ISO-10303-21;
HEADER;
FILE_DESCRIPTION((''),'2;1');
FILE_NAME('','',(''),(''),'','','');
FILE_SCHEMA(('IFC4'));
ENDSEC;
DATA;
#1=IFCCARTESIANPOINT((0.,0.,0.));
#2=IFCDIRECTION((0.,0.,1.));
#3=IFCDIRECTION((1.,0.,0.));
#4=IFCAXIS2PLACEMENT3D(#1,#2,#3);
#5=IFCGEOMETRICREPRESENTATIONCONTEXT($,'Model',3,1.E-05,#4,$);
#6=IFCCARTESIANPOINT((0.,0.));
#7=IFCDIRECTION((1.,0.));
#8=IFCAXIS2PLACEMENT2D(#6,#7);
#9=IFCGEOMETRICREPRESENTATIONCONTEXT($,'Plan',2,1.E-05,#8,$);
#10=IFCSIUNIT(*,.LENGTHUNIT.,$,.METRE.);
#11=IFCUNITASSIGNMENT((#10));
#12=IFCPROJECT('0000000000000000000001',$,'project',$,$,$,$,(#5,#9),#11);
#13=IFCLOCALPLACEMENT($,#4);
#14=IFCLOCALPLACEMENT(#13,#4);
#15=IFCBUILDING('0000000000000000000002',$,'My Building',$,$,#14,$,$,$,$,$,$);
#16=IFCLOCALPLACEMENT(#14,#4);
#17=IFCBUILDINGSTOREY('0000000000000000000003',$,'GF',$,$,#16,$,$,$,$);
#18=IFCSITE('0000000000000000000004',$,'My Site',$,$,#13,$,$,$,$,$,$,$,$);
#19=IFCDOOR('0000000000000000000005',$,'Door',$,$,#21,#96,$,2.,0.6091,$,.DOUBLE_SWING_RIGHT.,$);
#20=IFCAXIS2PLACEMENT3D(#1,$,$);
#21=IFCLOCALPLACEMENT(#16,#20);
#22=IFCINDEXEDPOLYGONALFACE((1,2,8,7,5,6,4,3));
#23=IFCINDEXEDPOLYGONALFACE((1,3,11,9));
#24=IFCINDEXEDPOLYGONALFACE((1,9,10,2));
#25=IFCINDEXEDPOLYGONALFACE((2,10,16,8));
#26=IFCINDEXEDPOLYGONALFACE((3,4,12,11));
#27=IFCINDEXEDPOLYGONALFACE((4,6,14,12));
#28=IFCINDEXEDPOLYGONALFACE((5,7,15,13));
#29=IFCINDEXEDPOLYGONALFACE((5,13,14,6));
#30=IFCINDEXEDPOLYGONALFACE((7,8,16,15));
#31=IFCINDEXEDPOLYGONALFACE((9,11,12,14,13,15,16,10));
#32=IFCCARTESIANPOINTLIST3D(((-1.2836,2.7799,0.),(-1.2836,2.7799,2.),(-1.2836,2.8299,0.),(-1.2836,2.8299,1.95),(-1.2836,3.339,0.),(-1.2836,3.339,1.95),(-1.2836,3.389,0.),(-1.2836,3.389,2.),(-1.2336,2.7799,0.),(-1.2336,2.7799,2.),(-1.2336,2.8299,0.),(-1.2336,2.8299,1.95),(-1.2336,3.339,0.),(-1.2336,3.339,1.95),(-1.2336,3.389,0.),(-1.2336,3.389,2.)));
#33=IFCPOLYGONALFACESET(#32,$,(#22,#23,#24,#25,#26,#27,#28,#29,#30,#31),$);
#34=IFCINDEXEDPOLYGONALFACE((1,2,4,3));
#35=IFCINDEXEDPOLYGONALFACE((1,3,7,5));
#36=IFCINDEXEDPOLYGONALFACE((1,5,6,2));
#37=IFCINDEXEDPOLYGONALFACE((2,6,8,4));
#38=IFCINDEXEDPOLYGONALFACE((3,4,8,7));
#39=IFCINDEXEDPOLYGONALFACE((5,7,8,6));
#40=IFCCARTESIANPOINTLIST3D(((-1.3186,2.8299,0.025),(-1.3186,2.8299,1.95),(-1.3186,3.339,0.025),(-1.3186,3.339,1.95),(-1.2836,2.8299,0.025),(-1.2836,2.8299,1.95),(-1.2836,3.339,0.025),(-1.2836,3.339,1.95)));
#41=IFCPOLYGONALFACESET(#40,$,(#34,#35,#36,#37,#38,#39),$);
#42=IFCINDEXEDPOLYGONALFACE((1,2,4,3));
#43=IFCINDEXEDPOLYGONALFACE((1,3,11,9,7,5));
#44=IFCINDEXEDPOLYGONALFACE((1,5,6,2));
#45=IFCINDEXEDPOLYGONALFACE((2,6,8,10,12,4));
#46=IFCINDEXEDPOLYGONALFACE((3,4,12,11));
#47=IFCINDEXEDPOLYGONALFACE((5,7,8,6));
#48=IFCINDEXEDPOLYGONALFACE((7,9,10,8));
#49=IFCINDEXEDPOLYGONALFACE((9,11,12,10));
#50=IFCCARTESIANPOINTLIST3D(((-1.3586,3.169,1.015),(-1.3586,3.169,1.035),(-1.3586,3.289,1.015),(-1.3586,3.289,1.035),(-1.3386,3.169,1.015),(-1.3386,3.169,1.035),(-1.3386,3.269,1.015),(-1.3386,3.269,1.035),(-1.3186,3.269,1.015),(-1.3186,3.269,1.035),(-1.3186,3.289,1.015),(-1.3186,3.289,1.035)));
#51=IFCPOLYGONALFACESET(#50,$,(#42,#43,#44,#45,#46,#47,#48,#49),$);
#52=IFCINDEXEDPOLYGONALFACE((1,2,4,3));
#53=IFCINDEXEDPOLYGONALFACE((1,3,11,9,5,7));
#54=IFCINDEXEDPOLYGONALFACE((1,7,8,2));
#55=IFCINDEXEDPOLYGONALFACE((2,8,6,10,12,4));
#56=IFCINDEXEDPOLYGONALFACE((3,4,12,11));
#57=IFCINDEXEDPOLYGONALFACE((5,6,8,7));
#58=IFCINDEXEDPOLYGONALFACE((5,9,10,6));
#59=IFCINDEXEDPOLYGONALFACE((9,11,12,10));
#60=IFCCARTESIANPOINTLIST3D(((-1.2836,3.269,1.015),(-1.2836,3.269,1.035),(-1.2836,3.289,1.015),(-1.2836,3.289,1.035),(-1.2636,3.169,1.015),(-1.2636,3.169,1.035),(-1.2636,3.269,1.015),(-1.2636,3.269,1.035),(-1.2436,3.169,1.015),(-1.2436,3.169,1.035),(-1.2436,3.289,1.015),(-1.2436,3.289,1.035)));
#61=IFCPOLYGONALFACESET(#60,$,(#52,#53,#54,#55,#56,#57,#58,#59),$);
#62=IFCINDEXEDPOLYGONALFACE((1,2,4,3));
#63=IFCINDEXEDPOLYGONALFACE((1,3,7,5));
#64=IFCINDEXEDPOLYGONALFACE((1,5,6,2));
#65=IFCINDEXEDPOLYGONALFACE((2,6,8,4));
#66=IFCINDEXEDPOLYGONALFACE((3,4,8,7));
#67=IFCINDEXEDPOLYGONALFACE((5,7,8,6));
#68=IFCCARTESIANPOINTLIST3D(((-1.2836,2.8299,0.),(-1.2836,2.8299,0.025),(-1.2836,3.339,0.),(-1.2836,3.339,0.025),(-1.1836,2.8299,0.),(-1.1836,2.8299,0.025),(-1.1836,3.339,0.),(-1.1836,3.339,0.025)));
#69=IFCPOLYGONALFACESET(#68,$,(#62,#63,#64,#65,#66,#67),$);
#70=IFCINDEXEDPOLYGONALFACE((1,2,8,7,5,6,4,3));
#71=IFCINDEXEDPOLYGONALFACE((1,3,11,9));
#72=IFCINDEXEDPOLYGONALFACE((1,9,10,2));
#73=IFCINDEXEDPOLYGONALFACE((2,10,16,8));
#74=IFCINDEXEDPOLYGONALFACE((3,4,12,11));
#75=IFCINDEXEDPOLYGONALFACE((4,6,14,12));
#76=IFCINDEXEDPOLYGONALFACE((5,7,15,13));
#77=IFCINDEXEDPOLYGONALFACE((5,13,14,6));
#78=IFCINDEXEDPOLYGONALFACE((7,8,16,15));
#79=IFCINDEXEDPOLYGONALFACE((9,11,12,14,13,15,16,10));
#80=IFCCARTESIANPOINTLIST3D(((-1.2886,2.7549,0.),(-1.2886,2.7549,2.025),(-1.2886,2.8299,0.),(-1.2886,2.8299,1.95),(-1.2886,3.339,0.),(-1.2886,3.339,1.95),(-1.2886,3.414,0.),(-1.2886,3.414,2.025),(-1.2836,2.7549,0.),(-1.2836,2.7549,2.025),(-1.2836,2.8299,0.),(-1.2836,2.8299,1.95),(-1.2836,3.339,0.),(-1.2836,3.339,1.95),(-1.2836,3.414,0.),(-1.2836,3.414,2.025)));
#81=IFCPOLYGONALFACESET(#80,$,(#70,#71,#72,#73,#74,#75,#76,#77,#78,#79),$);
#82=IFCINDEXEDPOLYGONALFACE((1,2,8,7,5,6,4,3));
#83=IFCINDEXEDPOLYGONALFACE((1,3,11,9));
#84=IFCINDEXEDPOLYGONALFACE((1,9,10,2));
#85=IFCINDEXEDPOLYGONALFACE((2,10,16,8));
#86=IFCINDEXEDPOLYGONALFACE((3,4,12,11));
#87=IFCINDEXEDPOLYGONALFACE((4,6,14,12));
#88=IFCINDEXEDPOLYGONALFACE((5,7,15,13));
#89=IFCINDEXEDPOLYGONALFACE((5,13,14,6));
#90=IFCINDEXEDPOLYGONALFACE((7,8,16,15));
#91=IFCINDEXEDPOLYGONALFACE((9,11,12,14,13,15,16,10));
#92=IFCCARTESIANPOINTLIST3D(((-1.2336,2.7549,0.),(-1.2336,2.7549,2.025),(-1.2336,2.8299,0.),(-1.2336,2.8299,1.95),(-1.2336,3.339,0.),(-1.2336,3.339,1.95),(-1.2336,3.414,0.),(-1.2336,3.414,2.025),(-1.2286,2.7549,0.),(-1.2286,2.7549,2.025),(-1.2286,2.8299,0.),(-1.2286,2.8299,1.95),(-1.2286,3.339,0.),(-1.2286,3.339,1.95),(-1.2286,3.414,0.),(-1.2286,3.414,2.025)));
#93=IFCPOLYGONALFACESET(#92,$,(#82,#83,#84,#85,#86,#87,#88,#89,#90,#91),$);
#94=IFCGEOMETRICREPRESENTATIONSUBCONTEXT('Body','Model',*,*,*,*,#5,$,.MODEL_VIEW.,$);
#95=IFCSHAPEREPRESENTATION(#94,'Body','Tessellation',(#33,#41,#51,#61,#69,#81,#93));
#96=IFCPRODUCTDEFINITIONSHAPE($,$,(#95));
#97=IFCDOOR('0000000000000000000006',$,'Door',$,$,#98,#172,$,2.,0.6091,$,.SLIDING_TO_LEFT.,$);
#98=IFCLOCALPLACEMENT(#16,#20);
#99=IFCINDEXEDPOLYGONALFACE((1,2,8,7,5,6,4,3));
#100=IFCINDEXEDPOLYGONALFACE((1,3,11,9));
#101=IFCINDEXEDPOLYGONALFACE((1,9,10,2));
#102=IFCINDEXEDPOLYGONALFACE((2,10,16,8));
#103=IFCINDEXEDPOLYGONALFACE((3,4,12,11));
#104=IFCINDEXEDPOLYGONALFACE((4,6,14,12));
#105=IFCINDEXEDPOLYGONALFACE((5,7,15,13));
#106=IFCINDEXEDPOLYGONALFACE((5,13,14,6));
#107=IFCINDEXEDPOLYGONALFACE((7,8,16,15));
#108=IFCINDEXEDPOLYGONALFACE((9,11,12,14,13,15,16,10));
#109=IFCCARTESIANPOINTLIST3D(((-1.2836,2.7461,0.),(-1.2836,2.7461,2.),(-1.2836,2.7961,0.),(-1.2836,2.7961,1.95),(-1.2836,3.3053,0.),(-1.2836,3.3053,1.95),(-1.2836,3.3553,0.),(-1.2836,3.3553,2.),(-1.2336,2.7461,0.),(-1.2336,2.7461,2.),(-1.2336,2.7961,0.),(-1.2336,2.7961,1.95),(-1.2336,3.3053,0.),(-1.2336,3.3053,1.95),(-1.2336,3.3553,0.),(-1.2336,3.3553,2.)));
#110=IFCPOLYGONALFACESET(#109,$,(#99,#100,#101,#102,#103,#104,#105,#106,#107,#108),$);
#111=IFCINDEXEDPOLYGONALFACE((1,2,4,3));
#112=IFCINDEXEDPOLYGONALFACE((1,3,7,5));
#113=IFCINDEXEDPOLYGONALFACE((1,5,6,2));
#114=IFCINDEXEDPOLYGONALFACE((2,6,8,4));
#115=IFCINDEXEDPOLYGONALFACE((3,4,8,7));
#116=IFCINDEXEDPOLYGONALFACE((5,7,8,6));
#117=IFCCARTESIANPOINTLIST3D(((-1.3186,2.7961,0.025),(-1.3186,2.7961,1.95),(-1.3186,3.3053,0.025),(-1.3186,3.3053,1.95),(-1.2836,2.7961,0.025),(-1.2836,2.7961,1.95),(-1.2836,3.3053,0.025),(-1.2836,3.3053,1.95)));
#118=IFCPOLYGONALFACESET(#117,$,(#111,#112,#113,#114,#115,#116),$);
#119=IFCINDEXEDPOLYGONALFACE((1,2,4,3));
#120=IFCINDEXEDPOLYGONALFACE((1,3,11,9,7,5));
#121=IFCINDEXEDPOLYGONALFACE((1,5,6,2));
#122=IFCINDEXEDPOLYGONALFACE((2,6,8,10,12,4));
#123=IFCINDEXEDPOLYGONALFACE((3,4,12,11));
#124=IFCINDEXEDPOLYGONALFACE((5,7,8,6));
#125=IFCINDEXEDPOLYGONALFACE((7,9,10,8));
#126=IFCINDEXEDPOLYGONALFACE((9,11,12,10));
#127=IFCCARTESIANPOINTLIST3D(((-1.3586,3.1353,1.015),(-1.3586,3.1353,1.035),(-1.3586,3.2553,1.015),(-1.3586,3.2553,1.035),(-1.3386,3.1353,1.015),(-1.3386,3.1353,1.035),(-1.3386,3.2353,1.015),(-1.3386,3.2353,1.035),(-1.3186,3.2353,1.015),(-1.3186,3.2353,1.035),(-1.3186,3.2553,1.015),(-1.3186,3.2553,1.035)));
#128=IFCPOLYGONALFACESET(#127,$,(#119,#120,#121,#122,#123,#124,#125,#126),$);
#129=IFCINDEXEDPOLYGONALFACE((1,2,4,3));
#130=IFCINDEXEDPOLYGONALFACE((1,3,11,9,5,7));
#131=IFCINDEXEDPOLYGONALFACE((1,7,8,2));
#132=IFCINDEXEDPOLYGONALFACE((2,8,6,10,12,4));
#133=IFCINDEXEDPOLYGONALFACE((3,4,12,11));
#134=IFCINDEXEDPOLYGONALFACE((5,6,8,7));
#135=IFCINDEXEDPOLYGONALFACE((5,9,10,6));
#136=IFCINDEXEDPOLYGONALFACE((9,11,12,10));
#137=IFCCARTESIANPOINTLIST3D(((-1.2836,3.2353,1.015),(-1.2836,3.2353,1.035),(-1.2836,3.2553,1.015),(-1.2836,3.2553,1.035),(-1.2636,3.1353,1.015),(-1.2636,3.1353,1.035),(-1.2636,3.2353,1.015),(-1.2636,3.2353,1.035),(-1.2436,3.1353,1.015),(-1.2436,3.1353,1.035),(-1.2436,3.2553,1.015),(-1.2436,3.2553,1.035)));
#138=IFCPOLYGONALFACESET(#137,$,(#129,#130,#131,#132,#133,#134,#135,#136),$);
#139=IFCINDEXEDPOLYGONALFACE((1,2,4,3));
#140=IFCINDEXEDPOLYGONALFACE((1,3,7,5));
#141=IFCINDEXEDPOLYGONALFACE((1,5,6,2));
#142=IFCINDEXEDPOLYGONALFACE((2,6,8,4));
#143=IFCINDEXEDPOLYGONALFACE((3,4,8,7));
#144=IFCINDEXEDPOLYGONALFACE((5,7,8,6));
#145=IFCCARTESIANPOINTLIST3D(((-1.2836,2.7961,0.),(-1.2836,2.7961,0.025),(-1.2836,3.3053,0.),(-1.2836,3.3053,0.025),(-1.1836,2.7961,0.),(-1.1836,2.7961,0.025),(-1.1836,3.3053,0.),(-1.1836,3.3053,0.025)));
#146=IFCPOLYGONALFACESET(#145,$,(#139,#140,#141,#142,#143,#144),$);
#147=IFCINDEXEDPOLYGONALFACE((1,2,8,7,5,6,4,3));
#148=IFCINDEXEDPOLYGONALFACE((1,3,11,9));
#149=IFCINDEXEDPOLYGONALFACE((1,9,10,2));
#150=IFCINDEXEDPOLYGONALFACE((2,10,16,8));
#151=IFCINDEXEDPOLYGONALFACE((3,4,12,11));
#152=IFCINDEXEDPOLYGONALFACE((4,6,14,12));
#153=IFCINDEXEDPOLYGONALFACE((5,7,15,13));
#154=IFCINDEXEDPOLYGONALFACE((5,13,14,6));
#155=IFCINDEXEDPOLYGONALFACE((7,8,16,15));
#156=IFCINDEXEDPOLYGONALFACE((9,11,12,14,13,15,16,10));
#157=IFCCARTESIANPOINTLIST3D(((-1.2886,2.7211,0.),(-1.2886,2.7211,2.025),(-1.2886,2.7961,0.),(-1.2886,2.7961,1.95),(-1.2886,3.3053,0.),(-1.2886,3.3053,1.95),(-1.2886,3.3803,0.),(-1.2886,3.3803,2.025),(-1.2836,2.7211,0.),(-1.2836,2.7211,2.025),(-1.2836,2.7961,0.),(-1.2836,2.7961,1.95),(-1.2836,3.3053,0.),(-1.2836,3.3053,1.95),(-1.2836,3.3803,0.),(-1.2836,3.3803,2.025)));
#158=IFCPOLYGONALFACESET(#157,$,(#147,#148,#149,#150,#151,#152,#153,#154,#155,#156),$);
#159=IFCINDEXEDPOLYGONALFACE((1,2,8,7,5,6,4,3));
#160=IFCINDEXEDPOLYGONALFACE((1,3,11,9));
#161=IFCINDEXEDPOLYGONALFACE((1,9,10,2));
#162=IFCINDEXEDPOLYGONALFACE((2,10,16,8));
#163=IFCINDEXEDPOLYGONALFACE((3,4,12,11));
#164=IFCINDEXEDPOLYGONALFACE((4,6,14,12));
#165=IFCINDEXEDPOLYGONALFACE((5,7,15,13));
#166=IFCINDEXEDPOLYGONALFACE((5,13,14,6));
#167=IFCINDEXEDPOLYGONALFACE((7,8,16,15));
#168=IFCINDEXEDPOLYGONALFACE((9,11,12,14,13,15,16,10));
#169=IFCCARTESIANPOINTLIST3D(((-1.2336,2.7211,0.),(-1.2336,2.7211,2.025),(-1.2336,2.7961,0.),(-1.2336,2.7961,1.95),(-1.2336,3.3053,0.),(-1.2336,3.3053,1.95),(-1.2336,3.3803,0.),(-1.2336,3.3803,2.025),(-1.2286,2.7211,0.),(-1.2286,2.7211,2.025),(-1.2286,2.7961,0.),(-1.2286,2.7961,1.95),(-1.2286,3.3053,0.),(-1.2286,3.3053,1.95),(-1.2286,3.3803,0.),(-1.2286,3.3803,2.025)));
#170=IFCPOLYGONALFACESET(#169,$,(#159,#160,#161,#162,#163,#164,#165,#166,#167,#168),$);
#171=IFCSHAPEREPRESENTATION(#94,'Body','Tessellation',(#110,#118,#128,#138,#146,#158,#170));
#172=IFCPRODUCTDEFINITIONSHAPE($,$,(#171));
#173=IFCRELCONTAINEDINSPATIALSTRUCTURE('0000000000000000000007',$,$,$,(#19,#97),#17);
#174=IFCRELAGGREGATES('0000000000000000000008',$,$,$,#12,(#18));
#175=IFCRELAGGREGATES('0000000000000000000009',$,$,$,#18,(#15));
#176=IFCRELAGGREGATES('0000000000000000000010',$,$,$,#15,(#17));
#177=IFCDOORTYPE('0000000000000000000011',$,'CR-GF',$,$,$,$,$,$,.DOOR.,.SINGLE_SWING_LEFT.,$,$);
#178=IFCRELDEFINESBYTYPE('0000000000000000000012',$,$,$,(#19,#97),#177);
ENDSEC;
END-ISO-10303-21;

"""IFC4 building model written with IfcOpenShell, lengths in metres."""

from ifc_helpers import new_model, entity, si_unit, frame, origin_with_axes, origin_2d_with_axis, place, context, subcontext, project, spatial, line, indexed_curve, outline, extrude, shape, source, transform, mapped, type_object, type_shapes, element, save


model = new_model("IFC4")

# Units and contexts
model_context = context("Model", 3, precision=1e-05, world=origin_with_axes())
plan_context = context("Plan", 2, precision=1e-05, world=origin_2d_with_axis())
body_context_1 = subcontext(model_context, "Body", "Model", "MODEL_VIEW")
body_context_2 = subcontext(plan_context, "Body", "Plan", "PLAN_VIEW")
ifc_project = project(units=[si_unit("LENGTHUNIT", "METRE")], contexts=[model_context, plan_context])

# Site, building, storey
site_placement = place(None, origin_with_axes())
site = spatial("IfcSite", under=ifc_project, at=site_placement, Name="My Site")
building_placement = place(site_placement, origin_with_axes())
building = spatial("IfcBuilding", under=site, at=building_placement, Name="My Building")
storey_placement = place(building_placement, origin_with_axes())
storey = spatial("IfcBuildingStorey", under=building, at=storey_placement, Name="GF")

# Doors
door_type_1 = type_object("IfcDoorType", Name="CR-GF", OperationType="SINGLE_SWING_LEFT", PredefinedType="DOOR")
shared_shape_1 = source(origin_with_axes(), body_context_1, "Body", "SweptSolid", [
    extrude(outline(indexed_curve([(0.0, 0.0), (0.0, 2.0), (0.6091, 2.0), (0.6091, 0.0), (0.5591, 0.0), (0.5591, 1.95), (0.05, 1.95), (0.05, 0.0)], segments=[line(1, 2, 3, 4, 5, 6, 7, 8, 1)])), frame((0.0, 0.0, 0.0), z_axis=(0.0, -1.0, 0.0), x_axis=(1.0, 0.0, 0.0)), (0.0, 0.0, -1.0), 0.05),
    extrude(outline(indexed_curve([(0.0, 0.0), (0.5091, 0.0), (0.5091, 0.035), (0.0, 0.035)], segments=[line(1, 2, 3, 4, 1)])), frame((0.05, -0.035, 0.025), z_axis=(0.0, 0.0, 1.0), x_axis=(1.0, 0.0, 0.0)), (0.0, 0.0, 1.0), 1.925),
    extrude(outline(indexed_curve([(0.0, 0.0), (0.0, -0.04), (0.12, -0.04), (0.12, -0.02), (0.02, -0.02), (0.02, 0.0)], segments=[line(1, 2, 3, 4, 5, 6, 1)])), frame((0.1, -0.035, 1.015), z_axis=(0.0, 0.0, 1.0), x_axis=(1.0, 0.0, 0.0)), (0.0, 0.0, 1.0), 0.02),
    extrude(outline(indexed_curve([(0.0, 0.0), (0.0, 0.04), (0.12, 0.04), (0.12, 0.02), (0.02, 0.02), (0.02, 0.0)], segments=[line(1, 2, 3, 4, 5, 6, 1)])), frame((0.1, 0.0, 1.015), z_axis=(0.0, 0.0, 1.0), x_axis=(1.0, 0.0, 0.0)), (0.0, 0.0, 1.0), 0.02),
    extrude(outline(indexed_curve([(0.0, 0.0), (0.5091, 0.0), (0.5091, 0.1), (0.0, 0.1)], segments=[line(1, 2, 3, 4, 1)])), frame((0.05, 0.0, 0.0), z_axis=(0.0, 0.0, 1.0), x_axis=(1.0, 0.0, 0.0)), (0.0, 0.0, 1.0), 0.025),
    extrude(outline(indexed_curve([(0.0, 0.0), (0.0, 2.025), (0.6591, 2.025), (0.6591, 0.0), (0.5841, 0.0), (0.5841, 1.95), (0.075, 1.95), (0.075, 0.0)], segments=[line(1, 2, 3, 4, 5, 6, 7, 8, 1)])), frame((-0.025, -0.005, 0.0), z_axis=(0.0, -1.0, 0.0), x_axis=(1.0, 0.0, 0.0)), (0.0, 0.0, -1.0), 0.005),
    extrude(outline(indexed_curve([(0.0, 0.0), (0.0, 2.025), (0.6591, 2.025), (0.6591, 0.0), (0.5841, 0.0), (0.5841, 1.95), (0.075, 1.95), (0.075, 0.0)], segments=[line(1, 2, 3, 4, 5, 6, 7, 8, 1)])), frame((-0.025, 0.05, 0.0), z_axis=(0.0, -1.0, 0.0), x_axis=(1.0, 0.0, 0.0)), (0.0, 0.0, -1.0), 0.005),
])
shared_shape_2 = source(origin_with_axes(), body_context_2, "Body", "Curve2D", [
    entity("IfcIndexedPolyCurve", entity("IfcCartesianPointList2D", [[0.0, 0.0], [0.05, 0.0], [0.05, 0.05], [0.0, 0.05]]), [entity("IfcLineIndex", [1, 2, 3, 4, 1])]),
    entity("IfcIndexedPolyCurve", entity("IfcCartesianPointList2D", [[0.6091, 0.0], [0.5591, 0.0], [0.5591, 0.05], [0.6091, 0.05]]), [entity("IfcLineIndex", [1, 2, 3, 4, 1])]),
    entity("IfcIndexedPolyCurve", entity("IfcCartesianPointList2D", [[0.8137, -0.035], [0.3046, -0.035], [0.3046, 0.0], [0.8137, 0.0]]), [entity("IfcLineIndex", [1, 2, 3, 4, 1])]),
])
type_shapes(door_type_1, [shared_shape_1, shared_shape_2])
placement_1 = place(storey_placement, frame((-1.1836, 2.64, 0.0), z_axis=(0.0, 0.0, 1.0), x_axis=(0.0, 1.0, 0.0)))
placement_2 = place(placement_1, frame((0.749, 0.1, 0.0), z_axis=(0.0, 0.0, 1.0), x_axis=(-1.0, 0.0, 0.0)))
door_1_placement = place(placement_2, frame((0.0, 0.0, 0.0), z_axis=(0.0, 0.0, 1.0), x_axis=(1.0, 0.0, 0.0)))
element("IfcDoor", 1, at=door_1_placement, inside=storey, type_object=door_type_1, Name="Door", OperationType="DOUBLE_SWING_RIGHT", OverallHeight=2.0, OverallWidth=0.6091, shapes=[
    shape(body_context_1, "Body", "MappedRepresentation", [mapped(shared_shape_1, transform((0.0, 0.0, 0.0), x_axis=(1.0, 0.0, 0.0), y_axis=(0.0, 1.0, 0.0), z_axis=(0.0, 0.0, 1.0), scale=1.0))]),
    shape(body_context_2, "Body", "MappedRepresentation", [mapped(shared_shape_2, transform((0.0, 0.0, 0.0), x_axis=(1.0, 0.0, 0.0), y_axis=(0.0, 1.0, 0.0), z_axis=(0.0, 0.0, 1.0), scale=1.0))]),
])
placement_3 = place(placement_1, frame((0.7153, 0.1, 0.0), z_axis=(0.0, 0.0, 1.0), x_axis=(-1.0, 0.0, 0.0)))
door_2_placement = place(placement_3, frame((0.0, 0.0, 0.0), z_axis=(0.0, 0.0, 1.0), x_axis=(1.0, 0.0, 0.0)))
element("IfcDoor", 2, at=door_2_placement, inside=storey, type_object=door_type_1, Name="Door", OperationType="SLIDING_TO_LEFT", OverallHeight=2.0, OverallWidth=0.6091, shapes=[
    shape(body_context_1, "Body", "MappedRepresentation", [mapped(shared_shape_1, transform((0.0, 0.0, 0.0), x_axis=(1.0, 0.0, 0.0), y_axis=(0.0, 1.0, 0.0), z_axis=(0.0, 0.0, 1.0), scale=1.0))]),
    shape(body_context_2, "Body", "MappedRepresentation", [mapped(shared_shape_2, transform((0.0, 0.0, 0.0), x_axis=(1.0, 0.0, 0.0), y_axis=(0.0, 1.0, 0.0), z_axis=(0.0, 0.0, 1.0), scale=1.0))]),
])

save(model, "model.ifc")
